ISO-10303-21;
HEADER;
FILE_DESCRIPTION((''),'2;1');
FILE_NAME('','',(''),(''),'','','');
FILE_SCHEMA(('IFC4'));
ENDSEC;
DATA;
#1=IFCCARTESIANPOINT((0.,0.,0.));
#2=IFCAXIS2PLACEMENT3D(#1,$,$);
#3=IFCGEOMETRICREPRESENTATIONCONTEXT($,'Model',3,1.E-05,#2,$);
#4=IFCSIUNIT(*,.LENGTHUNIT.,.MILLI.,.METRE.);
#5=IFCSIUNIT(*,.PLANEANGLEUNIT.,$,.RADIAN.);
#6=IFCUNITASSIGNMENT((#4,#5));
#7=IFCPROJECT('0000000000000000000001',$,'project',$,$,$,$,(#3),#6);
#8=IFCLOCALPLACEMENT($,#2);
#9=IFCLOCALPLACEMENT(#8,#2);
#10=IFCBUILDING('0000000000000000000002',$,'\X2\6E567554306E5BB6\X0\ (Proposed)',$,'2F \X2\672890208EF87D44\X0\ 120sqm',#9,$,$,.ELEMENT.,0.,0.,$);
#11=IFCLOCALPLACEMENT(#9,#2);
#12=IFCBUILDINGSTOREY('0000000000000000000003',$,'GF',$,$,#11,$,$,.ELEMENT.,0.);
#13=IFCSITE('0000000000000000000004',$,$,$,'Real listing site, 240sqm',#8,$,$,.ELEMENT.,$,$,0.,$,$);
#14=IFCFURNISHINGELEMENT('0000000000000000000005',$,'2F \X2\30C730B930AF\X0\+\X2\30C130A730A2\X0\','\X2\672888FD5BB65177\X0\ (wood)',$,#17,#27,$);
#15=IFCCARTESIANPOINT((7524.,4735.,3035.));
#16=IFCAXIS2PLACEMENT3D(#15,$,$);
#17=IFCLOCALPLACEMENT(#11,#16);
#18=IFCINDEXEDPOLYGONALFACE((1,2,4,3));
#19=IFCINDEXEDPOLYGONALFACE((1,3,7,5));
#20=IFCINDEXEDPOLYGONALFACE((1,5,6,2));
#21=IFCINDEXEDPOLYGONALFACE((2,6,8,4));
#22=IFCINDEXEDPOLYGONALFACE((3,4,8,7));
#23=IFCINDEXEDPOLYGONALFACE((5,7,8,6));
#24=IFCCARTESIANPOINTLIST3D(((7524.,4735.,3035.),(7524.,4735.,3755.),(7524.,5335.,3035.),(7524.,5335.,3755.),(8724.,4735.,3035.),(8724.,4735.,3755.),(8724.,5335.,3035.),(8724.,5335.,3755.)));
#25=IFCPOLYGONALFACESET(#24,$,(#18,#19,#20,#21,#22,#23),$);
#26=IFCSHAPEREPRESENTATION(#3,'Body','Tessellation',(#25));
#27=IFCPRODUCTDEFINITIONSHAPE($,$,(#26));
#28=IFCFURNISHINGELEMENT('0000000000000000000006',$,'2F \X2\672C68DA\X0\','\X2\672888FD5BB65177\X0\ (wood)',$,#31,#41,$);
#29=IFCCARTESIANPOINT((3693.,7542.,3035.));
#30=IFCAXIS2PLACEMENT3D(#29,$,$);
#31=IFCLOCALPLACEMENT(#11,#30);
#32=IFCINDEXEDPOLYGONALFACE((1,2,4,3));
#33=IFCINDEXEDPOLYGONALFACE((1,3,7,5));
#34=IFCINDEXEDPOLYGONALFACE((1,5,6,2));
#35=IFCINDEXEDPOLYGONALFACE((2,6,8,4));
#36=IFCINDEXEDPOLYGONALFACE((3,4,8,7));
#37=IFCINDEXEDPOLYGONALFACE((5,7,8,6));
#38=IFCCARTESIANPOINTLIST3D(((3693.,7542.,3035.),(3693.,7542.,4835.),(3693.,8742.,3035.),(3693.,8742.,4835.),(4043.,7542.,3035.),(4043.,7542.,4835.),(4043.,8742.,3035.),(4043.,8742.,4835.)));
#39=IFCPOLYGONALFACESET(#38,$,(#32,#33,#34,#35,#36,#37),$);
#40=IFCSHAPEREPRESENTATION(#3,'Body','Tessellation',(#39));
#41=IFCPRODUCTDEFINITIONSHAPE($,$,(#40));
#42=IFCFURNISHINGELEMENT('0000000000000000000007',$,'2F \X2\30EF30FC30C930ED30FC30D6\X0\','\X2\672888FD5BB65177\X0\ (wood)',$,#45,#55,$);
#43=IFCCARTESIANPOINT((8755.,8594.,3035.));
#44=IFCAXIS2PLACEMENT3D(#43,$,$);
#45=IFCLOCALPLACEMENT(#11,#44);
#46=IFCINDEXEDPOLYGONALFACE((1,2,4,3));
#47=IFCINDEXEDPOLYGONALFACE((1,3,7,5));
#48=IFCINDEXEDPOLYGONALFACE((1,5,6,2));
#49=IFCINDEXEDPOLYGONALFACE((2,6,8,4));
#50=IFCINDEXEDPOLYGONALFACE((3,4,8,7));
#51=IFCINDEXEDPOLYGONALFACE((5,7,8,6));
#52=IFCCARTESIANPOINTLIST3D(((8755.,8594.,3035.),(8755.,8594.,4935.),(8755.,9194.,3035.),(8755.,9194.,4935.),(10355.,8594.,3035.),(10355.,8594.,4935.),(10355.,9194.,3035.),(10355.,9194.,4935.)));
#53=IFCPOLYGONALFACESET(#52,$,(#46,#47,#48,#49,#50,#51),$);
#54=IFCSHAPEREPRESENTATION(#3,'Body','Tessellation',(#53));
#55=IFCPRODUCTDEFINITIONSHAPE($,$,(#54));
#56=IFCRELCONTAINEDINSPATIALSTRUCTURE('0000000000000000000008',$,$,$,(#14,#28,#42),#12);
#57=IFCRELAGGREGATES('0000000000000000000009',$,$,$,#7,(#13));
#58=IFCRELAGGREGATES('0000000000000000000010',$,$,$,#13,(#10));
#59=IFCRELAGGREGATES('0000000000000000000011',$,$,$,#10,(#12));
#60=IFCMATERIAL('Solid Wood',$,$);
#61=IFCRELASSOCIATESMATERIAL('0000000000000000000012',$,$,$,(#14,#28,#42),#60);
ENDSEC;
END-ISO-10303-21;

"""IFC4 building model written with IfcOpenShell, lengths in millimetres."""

from ifc_helpers import new_model, si_unit, frame, frame_2d, origin, place, context, project, spatial, rectangle, extrude, material, element, save


model = new_model("IFC4")

# Units and contexts
model_context = context("Model", 3, precision=1e-05, world=origin())
ifc_project = project(units=[si_unit("LENGTHUNIT", "METRE", prefix="MILLI"), si_unit("PLANEANGLEUNIT", "RADIAN")], contexts=[model_context])

# Site, building, storey
site_placement = place(None, origin())
site = spatial("IfcSite", under=ifc_project, at=site_placement, ObjectType="Real listing site, 240sqm", CompositionType="ELEMENT", RefElevation=0.0)
building_placement = place(site_placement, origin())
building = spatial("IfcBuilding", under=site, at=building_placement, Name="湖畔の家 (Proposed)", ObjectType="2F 木造軸組 120sqm", CompositionType="ELEMENT", ElevationOfRefHeight=0.0, ElevationOfTerrain=0.0)
storey_placement = place(building_placement, origin())
storey = spatial("IfcBuildingStorey", under=building, at=storey_placement, Name="GF", CompositionType="ELEMENT", Elevation=0.0)

# Shared definitions
ifc_material_1 = material(Name="Solid Wood")

# Furnishing elements
furnishing_1_placement = place(storey_placement, frame((7524.0, 4735.0, 3035.0)))
element("IfcFurnishingElement", 1, at=furnishing_1_placement, inside=storey, material=ifc_material_1, Name="2F デスク+チェア", Description="木製家具 (wood)", context=model_context, shape_type="SweptSolid", body=[
    extrude(rectangle(XDim=1200.0, YDim=600.0, at=frame_2d((600.0, 300.0))), frame((7524.0, 4735.0, 3035.0)), (0.0, 0.0, 1.0), 720.0),
])
furnishing_2_placement = place(storey_placement, frame((3693.0, 7542.0, 3035.0)))
element("IfcFurnishingElement", 2, at=furnishing_2_placement, inside=storey, material=ifc_material_1, Name="2F 本棚", Description="木製家具 (wood)", context=model_context, shape_type="SweptSolid", body=[
    extrude(rectangle(XDim=350.0, YDim=1200.0, at=frame_2d((175.0, 600.0))), frame((3693.0, 7542.0, 3035.0)), (0.0, 0.0, 1.0), 1800.0),
])
furnishing_3_placement = place(storey_placement, frame((8755.0, 8594.0, 3035.0)))
element("IfcFurnishingElement", 3, at=furnishing_3_placement, inside=storey, material=ifc_material_1, Name="2F ワードローブ", Description="木製家具 (wood)", context=model_context, shape_type="SweptSolid", body=[
    extrude(rectangle(XDim=1600.0, YDim=600.0, at=frame_2d((800.0, 300.0))), frame((8755.0, 8594.0, 3035.0)), (0.0, 0.0, 1.0), 1900.0),
])

save(model, "model.ifc")
